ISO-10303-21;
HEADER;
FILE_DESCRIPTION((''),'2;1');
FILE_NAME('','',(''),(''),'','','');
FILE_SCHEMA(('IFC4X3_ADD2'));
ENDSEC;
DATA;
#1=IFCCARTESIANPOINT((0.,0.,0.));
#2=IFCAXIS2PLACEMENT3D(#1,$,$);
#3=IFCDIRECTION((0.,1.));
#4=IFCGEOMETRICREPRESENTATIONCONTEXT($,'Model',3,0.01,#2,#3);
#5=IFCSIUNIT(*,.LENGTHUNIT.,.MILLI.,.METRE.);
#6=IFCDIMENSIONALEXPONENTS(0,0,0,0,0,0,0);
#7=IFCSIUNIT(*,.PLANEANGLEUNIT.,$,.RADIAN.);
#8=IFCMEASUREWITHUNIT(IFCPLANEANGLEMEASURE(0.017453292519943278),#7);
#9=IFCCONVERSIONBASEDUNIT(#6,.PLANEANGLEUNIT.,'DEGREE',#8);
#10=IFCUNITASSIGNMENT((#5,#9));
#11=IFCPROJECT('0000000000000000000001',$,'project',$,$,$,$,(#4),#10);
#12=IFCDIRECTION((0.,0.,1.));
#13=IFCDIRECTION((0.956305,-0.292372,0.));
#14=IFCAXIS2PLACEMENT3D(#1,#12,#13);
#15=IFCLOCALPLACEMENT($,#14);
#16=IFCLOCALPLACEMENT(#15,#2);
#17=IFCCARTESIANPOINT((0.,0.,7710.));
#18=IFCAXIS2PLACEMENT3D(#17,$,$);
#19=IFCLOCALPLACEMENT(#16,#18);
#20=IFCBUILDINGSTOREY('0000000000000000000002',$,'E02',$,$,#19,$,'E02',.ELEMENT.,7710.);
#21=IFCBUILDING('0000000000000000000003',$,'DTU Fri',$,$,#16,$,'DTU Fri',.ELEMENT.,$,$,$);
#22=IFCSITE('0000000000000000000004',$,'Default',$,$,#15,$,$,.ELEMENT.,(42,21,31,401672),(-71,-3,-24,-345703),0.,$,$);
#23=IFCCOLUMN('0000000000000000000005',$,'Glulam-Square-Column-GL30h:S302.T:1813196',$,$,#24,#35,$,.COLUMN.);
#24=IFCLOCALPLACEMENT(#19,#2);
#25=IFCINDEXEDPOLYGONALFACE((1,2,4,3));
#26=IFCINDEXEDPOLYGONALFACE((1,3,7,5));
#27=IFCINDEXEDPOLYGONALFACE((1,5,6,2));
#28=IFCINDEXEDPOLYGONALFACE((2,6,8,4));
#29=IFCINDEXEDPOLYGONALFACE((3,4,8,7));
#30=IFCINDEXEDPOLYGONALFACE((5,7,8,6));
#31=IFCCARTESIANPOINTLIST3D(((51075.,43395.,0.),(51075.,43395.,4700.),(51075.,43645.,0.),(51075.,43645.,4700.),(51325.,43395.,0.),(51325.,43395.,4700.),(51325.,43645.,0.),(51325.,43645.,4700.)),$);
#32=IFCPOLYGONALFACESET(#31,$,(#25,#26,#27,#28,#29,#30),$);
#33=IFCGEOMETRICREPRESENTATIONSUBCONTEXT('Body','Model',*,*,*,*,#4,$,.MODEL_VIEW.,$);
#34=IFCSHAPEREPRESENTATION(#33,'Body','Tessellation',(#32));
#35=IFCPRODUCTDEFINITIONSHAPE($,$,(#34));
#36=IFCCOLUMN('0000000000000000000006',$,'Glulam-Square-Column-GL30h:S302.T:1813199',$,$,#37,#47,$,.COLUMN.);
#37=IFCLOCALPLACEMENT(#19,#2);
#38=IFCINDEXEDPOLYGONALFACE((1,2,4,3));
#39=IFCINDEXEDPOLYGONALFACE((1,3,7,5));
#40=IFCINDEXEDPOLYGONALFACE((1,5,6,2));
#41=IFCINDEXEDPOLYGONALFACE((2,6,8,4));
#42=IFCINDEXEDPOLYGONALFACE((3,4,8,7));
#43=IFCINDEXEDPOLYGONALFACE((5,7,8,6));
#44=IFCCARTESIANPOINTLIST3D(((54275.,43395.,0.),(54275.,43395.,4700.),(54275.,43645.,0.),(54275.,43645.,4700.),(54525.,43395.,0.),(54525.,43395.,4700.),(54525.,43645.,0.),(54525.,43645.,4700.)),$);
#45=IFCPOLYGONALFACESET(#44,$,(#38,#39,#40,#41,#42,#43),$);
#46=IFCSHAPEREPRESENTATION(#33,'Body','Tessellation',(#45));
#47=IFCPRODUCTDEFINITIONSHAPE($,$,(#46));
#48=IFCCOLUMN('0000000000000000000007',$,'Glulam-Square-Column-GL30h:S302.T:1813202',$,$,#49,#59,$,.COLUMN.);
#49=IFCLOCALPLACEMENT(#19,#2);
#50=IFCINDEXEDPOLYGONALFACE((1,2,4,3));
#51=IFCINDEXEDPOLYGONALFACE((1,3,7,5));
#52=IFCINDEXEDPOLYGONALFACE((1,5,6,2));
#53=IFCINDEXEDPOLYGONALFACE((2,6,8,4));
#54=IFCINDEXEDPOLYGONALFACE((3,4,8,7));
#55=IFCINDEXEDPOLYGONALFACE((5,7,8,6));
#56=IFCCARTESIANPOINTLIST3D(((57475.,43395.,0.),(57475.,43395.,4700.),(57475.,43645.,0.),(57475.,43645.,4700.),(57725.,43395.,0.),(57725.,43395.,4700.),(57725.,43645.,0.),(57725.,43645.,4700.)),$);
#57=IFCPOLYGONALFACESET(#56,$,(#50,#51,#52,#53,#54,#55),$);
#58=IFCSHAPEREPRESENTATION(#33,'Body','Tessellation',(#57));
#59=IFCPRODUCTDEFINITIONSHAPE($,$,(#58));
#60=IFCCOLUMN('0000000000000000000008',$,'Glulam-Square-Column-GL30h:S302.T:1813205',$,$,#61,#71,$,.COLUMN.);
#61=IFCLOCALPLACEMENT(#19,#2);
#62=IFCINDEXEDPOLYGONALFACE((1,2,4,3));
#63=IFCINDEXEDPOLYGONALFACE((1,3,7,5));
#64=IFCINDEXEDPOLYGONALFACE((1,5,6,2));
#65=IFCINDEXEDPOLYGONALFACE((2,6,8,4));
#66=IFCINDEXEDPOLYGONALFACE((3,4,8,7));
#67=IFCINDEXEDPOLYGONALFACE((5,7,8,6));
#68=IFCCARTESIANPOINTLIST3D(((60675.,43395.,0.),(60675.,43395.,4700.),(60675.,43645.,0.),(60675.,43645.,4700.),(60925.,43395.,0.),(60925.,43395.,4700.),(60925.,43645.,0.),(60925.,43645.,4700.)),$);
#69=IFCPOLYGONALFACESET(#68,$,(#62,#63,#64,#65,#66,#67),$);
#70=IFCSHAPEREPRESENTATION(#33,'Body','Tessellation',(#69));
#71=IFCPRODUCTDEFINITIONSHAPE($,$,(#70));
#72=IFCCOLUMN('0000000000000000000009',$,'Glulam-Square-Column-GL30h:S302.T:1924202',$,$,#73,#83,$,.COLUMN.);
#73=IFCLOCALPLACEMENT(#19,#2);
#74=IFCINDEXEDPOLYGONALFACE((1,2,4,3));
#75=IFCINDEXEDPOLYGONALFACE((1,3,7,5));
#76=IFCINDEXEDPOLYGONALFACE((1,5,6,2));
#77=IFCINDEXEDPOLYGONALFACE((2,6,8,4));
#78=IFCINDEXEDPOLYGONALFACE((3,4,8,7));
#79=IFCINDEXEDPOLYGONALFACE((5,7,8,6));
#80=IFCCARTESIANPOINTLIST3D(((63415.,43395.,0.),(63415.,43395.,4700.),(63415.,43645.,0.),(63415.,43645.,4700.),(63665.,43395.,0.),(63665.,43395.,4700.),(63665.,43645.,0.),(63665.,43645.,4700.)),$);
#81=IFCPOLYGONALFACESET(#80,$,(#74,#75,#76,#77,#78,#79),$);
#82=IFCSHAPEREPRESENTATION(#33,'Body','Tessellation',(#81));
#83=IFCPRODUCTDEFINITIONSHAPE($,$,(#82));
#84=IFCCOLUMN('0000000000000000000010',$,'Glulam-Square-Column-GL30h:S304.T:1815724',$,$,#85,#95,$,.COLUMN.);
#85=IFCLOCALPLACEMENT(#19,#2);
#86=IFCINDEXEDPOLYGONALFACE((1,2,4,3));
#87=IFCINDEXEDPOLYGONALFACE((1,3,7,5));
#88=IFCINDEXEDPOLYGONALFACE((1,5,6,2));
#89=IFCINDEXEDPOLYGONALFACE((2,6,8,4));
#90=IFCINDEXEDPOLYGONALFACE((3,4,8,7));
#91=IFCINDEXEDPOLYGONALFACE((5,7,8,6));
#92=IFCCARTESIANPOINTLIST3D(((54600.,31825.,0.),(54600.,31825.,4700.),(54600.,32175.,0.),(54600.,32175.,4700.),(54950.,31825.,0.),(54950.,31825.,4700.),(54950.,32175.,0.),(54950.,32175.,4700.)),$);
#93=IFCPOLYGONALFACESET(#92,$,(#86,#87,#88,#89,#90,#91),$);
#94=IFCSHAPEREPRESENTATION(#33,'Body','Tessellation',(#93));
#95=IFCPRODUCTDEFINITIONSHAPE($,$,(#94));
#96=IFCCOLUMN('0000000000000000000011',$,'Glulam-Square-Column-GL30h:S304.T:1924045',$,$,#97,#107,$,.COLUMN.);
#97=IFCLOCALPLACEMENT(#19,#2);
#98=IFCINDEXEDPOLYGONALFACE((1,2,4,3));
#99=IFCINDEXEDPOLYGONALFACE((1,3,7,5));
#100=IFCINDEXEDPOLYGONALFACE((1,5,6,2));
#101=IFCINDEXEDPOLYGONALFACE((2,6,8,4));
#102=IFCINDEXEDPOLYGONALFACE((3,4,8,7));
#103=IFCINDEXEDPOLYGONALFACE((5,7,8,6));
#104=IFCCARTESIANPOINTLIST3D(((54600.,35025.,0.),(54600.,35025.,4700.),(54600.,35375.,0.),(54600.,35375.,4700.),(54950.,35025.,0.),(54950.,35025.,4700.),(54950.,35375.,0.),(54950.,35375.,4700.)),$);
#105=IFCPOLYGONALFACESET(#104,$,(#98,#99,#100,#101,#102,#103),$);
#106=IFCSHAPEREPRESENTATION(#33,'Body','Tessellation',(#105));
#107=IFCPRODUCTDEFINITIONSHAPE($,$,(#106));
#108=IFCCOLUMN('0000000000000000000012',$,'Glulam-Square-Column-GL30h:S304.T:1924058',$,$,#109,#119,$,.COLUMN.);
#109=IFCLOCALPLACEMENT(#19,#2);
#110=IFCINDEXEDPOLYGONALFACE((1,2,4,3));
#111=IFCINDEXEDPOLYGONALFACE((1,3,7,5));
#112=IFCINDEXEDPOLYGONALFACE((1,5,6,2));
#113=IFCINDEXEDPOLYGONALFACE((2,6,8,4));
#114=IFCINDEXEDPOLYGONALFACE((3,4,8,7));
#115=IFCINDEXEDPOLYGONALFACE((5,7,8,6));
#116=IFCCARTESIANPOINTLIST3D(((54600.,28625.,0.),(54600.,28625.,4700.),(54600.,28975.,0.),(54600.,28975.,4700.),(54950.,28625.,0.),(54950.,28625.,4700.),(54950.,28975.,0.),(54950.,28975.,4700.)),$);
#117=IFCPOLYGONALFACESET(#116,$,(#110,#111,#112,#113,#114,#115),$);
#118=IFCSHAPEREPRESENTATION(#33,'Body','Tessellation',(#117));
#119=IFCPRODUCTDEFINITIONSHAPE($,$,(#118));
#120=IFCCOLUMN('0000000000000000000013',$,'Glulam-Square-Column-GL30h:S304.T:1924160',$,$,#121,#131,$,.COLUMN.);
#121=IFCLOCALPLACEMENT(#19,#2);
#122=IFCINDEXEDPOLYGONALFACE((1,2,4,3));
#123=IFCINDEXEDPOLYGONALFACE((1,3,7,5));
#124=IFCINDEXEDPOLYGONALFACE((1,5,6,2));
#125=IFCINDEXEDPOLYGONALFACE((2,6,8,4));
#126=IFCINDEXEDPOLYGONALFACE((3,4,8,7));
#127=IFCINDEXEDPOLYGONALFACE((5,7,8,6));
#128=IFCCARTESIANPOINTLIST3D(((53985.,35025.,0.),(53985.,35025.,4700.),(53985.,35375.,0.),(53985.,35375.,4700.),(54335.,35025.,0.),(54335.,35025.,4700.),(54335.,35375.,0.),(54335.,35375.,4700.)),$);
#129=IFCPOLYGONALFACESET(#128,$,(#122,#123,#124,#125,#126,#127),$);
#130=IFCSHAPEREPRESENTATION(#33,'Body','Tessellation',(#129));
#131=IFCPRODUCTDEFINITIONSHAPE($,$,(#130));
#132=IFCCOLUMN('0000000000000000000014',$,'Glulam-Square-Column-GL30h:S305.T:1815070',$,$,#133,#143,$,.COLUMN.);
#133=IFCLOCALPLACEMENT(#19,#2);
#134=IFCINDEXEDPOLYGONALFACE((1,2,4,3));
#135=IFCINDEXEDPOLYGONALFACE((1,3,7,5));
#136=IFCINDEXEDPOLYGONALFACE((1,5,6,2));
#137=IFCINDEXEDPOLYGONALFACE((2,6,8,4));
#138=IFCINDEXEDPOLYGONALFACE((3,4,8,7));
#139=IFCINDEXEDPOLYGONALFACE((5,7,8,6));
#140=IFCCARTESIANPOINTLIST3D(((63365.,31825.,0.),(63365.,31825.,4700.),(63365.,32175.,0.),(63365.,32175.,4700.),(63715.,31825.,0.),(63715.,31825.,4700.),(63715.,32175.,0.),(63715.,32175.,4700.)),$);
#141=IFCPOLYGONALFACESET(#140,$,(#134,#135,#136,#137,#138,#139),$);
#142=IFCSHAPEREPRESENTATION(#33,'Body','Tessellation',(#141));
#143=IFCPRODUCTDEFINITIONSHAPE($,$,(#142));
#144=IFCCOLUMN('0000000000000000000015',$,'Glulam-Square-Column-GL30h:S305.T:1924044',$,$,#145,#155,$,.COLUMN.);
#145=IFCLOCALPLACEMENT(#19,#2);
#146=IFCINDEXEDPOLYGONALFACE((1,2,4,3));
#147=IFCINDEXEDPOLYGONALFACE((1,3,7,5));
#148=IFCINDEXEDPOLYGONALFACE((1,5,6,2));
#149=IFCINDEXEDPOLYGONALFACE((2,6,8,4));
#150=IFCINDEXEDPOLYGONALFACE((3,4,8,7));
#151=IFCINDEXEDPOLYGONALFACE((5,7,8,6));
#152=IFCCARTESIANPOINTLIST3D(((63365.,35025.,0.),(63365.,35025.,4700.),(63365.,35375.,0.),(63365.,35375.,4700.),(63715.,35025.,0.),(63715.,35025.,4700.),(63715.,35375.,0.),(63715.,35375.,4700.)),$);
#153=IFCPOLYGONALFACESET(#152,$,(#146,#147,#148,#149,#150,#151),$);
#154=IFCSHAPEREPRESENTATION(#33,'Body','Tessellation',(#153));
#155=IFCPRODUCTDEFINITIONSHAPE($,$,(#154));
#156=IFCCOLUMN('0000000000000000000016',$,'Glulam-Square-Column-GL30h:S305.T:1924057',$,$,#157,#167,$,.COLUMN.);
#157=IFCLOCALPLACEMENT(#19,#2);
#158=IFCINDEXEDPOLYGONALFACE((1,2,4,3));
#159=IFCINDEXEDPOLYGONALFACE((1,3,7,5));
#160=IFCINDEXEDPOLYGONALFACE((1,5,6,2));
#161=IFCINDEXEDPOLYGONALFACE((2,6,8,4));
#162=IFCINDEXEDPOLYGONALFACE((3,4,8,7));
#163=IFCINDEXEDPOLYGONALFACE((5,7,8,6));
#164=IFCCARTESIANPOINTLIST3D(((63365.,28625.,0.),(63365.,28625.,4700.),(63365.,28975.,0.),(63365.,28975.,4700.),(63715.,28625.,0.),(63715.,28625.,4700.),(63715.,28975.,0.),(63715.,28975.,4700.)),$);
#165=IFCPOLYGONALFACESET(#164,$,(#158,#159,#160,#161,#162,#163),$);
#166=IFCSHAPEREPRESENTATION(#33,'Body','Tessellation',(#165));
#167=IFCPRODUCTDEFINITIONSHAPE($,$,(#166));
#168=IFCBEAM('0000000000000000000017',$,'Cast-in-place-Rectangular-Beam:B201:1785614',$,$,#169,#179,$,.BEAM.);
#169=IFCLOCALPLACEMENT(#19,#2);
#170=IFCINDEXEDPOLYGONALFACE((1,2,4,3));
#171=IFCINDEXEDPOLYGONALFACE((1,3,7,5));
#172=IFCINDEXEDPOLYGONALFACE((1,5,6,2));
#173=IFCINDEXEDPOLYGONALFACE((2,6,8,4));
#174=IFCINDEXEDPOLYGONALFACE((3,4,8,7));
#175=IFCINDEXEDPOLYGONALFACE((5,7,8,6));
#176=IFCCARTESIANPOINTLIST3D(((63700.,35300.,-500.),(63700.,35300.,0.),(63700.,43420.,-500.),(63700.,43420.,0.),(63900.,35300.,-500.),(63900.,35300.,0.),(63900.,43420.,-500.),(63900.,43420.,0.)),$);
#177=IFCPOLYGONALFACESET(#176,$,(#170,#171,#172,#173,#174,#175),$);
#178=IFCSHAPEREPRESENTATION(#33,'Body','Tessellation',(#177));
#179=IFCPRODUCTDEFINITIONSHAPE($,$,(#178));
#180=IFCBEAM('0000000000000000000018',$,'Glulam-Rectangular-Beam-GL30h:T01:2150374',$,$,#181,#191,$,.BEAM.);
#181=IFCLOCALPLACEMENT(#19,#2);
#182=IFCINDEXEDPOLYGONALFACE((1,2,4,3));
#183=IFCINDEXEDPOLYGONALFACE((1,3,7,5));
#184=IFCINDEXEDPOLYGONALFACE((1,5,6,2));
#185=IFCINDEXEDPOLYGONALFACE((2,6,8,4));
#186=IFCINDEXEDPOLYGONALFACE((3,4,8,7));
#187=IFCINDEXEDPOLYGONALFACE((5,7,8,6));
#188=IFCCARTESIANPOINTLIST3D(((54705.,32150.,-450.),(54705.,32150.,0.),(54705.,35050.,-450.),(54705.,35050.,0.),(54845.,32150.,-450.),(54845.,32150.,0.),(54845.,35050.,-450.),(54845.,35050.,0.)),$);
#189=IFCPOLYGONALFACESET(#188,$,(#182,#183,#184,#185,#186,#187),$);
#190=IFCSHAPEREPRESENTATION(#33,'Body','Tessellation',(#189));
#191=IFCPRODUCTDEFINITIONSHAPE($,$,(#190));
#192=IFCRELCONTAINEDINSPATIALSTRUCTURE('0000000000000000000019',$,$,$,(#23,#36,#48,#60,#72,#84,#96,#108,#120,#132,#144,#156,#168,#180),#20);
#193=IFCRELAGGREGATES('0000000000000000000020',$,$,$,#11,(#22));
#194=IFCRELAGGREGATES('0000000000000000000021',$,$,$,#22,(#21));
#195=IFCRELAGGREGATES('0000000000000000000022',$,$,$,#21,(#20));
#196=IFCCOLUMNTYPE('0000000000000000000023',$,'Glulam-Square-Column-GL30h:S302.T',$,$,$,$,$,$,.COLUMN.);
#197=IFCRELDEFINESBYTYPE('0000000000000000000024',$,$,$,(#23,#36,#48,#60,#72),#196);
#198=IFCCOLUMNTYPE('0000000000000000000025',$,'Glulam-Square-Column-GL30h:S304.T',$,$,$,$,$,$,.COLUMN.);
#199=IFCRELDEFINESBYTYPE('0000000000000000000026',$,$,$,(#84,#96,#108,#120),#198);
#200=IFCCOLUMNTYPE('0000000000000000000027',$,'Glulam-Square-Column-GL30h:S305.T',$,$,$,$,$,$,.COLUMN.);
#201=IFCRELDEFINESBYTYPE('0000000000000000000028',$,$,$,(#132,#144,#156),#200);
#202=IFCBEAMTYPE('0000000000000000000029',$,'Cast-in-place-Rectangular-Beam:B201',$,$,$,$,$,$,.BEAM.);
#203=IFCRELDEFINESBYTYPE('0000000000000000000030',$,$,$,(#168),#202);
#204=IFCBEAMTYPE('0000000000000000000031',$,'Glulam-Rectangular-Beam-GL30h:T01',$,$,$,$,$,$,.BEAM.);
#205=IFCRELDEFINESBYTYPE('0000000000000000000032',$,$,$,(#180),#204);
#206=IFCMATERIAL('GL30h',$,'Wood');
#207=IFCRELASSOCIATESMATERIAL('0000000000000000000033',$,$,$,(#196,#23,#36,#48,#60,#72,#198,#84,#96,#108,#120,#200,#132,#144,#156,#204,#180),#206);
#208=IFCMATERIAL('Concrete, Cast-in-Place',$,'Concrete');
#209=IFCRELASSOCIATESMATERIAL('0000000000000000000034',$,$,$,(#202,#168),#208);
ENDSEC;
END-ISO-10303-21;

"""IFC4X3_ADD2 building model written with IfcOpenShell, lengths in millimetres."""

from ifc_helpers import new_model, entity, si_unit, converted_unit, direction, frame, origin, origin_2d_with_axis, place, context, subcontext, project, spatial, rectangle, extrude, source, transform, mapped, material, material_profile, profile_set, profile_usage, type_object, type_shapes, element, save


model = new_model("IFC4X3_ADD2")

# Units and contexts
model_context = context("Model", 3, precision=0.01, world=origin(), true_north=direction((0.0, 1.0)))
body_context = subcontext(model_context, "Body", "Model", "MODEL_VIEW")
ifc_project = project(units=[si_unit("LENGTHUNIT", "METRE", prefix="MILLI"), converted_unit("PLANEANGLEUNIT", "DEGREE", entity("IfcPlaneAngleMeasure", 0.017453292519943278), si_unit("PLANEANGLEUNIT", "RADIAN"), dimensions=[0, 0, 0, 0, 0, 0, 0])], contexts=[model_context])

# Site, building, storey
site_placement = place(None, frame((0.0, 0.0, 0.0), z_axis=(0.0, 0.0, 1.0), x_axis=(0.956305, -0.292372, 0.0)))
site = spatial("IfcSite", under=ifc_project, at=site_placement, Name="Default", CompositionType="ELEMENT", RefLatitude=(42, 21, 31, 401672), RefLongitude=(-71, -3, -24, -345703), RefElevation=0.0)
building_placement = place(site_placement, origin())
building = spatial("IfcBuilding", under=site, at=building_placement, Name="DTU Fri", LongName="DTU Fri", CompositionType="ELEMENT")
storey_placement = place(building_placement, frame((0.0, 0.0, 7710.0)))
storey = spatial("IfcBuildingStorey", under=building, at=storey_placement, Name="E02", LongName="E02", CompositionType="ELEMENT", Elevation=7710.0)

# Columns
ifc_material_1 = material(Name="GL30h", Category="Wood")
ifc_material_profile_1 = material_profile(ifc_material_1, rectangle(XDim=250.0, YDim=250.0, at=origin_2d_with_axis()), Name="S302.T")
ifc_profile_set_1 = profile_set([ifc_material_profile_1], Name="S302.T")
ifc_profile_usage_1 = profile_usage(ifc_profile_set_1)
column_type_1 = type_object("IfcColumnType", Name="Glulam-Square-Column-GL30h:S302.T", PredefinedType="COLUMN", material=ifc_profile_set_1)
shared_shape_1 = source(origin(), body_context, "Body", "SweptSolid", [
    extrude(rectangle(XDim=250.0, YDim=250.0, at=origin_2d_with_axis()), frame((0.0, 0.0, 7710.0), z_axis=(0.0, 0.0, 1.0), x_axis=(0.0, 1.0, 0.0)), (0.0, 0.0, 1.0), 4700.0),
])
type_shapes(column_type_1, [shared_shape_1])
for number, where, name in (
    (1, (51200.0, 43520.0, -7710.0), "Glulam-Square-Column-GL30h:S302.T:1813196"),
    (2, (54400.0, 43520.0, -7710.0), "Glulam-Square-Column-GL30h:S302.T:1813199"),
    (3, (57600.0, 43520.0, -7710.0), "Glulam-Square-Column-GL30h:S302.T:1813202"),
    (4, (60800.0, 43520.0, -7710.0), "Glulam-Square-Column-GL30h:S302.T:1813205"),
    (5, (63540.0, 43520.0, -7710.0), "Glulam-Square-Column-GL30h:S302.T:1924202"),
):
    element("IfcColumn", number, at=place(storey_placement, frame(where)), inside=storey, type_object=column_type_1, material=ifc_profile_usage_1, Name=name, PredefinedType="COLUMN", context=body_context, shape_type="MappedRepresentation", body=[
        mapped(shared_shape_1, transform((0.0, 0.0, 0.0), scale=1.0)),
    ])
ifc_material_profile_2 = material_profile(ifc_material_1, rectangle(XDim=350.0, YDim=350.0, at=origin_2d_with_axis()), Name="S304.T")
ifc_profile_set_2 = profile_set([ifc_material_profile_2], Name="S304.T")
ifc_profile_usage_2 = profile_usage(ifc_profile_set_2)
column_type_2 = type_object("IfcColumnType", Name="Glulam-Square-Column-GL30h:S304.T", PredefinedType="COLUMN", material=ifc_profile_set_2)
shared_shape_2 = source(origin(), body_context, "Body", "SweptSolid", [
    extrude(rectangle(XDim=350.0, YDim=350.0, at=origin_2d_with_axis()), frame((0.0, 0.0, 7710.0), z_axis=(0.0, 0.0, 1.0), x_axis=(0.0, 1.0, 0.0)), (0.0, 0.0, 1.0), 4700.0),
])
type_shapes(column_type_2, [shared_shape_2])
for number, where, name in (
    (6, (54775.0, 32000.0, -7710.0), "Glulam-Square-Column-GL30h:S304.T:1815724"),
    (7, (54775.0, 35200.0, -7710.0), "Glulam-Square-Column-GL30h:S304.T:1924045"),
    (8, (54775.0, 28800.0, -7710.0), "Glulam-Square-Column-GL30h:S304.T:1924058"),
    (9, (54160.0, 35200.0, -7710.0), "Glulam-Square-Column-GL30h:S304.T:1924160"),
):
    element("IfcColumn", number, at=place(storey_placement, frame(where)), inside=storey, type_object=column_type_2, material=ifc_profile_usage_2, Name=name, PredefinedType="COLUMN", context=body_context, shape_type="MappedRepresentation", body=[
        mapped(shared_shape_2, transform((0.0, 0.0, 0.0), scale=1.0)),
    ])
ifc_material_profile_3 = material_profile(ifc_material_1, rectangle(XDim=350.0, YDim=350.0, at=origin_2d_with_axis()), Name="S305.T")
ifc_profile_set_3 = profile_set([ifc_material_profile_3], Name="S305.T")
ifc_profile_usage_3 = profile_usage(ifc_profile_set_3)
column_type_3 = type_object("IfcColumnType", Name="Glulam-Square-Column-GL30h:S305.T", PredefinedType="COLUMN", material=ifc_profile_set_3)
shared_shape_3 = source(origin(), body_context, "Body", "SweptSolid", [
    extrude(rectangle(XDim=350.0, YDim=350.0, at=origin_2d_with_axis()), frame((0.0, 0.0, 7710.0), z_axis=(0.0, 0.0, 1.0), x_axis=(0.0, 1.0, 0.0)), (0.0, 0.0, 1.0), 4700.0),
])
type_shapes(column_type_3, [shared_shape_3])
for number, where, name in (
    (10, (63540.0, 32000.0, -7710.0), "Glulam-Square-Column-GL30h:S305.T:1815070"),
    (11, (63540.0, 35200.0, -7710.0), "Glulam-Square-Column-GL30h:S305.T:1924044"),
    (12, (63540.0, 28800.0, -7710.0), "Glulam-Square-Column-GL30h:S305.T:1924057"),
):
    element("IfcColumn", number, at=place(storey_placement, frame(where)), inside=storey, type_object=column_type_3, material=ifc_profile_usage_3, Name=name, PredefinedType="COLUMN", context=body_context, shape_type="MappedRepresentation", body=[
        mapped(shared_shape_3, transform((0.0, 0.0, 0.0), scale=1.0)),
    ])

# Beams
ifc_material_2 = material(Name="Concrete, Cast-in-Place", Category="Concrete")
ifc_material_profile_4 = material_profile(ifc_material_2, rectangle(XDim=500.0, YDim=200.0, at=origin_2d_with_axis()), Name="B201")
ifc_profile_set_4 = profile_set([ifc_material_profile_4], Name="B201")
ifc_profile_usage_4 = profile_usage(ifc_profile_set_4, cardinal=8)
beam_type_1 = type_object("IfcBeamType", Name="Cast-in-place-Rectangular-Beam:B201", PredefinedType="BEAM", material=ifc_profile_set_4)
shared_shape_4 = source(origin(), body_context, "Body", "SweptSolid", [
    extrude(rectangle(XDim=500.0, YDim=200.0, at=origin_2d_with_axis()), frame((-4070.0, 0.0, 0.0), z_axis=(1.0, 0.0, 0.0), x_axis=(0.0, 0.0, -1.0)), (0.0, 0.0, 1.0), 8120.0),
])
type_shapes(beam_type_1, [shared_shape_4])
beam_1_placement = place(storey_placement, frame((63800.0, 39350.0, -250.0), z_axis=(0.0, 0.0, 1.0), x_axis=(0.0, -1.0, 0.0)))
element("IfcBeam", 13, at=beam_1_placement, inside=storey, type_object=beam_type_1, material=ifc_profile_usage_4, Name="Cast-in-place-Rectangular-Beam:B201:1785614", PredefinedType="BEAM", context=body_context, shape_type="MappedRepresentation", body=[
    mapped(shared_shape_4, transform((0.0, 0.0, 0.0), scale=1.0)),
])
ifc_material_profile_5 = material_profile(ifc_material_1, rectangle(XDim=450.0, YDim=140.0, at=origin_2d_with_axis()), Name="T01")
ifc_profile_set_5 = profile_set([ifc_material_profile_5], Name="T01")
ifc_profile_usage_5 = profile_usage(ifc_profile_set_5, cardinal=8)
beam_type_2 = type_object("IfcBeamType", Name="Glulam-Rectangular-Beam-GL30h:T01", PredefinedType="BEAM", material=ifc_profile_set_5)
shared_shape_5 = source(origin(), body_context, "Body", "SweptSolid", [
    extrude(rectangle(XDim=450.0, YDim=140.0, at=origin_2d_with_axis()), frame((-1450.0, 0.0, 0.0), z_axis=(1.0, 0.0, 0.0), x_axis=(0.0, 0.0, -1.0)), (0.0, 0.0, 1.0), 2900.0),
])
type_shapes(beam_type_2, [shared_shape_5])
beam_2_placement = place(storey_placement, frame((54775.0, 33600.0, -225.0), z_axis=(0.0, 0.0, 1.0), x_axis=(0.0, 1.0, 0.0)))
element("IfcBeam", 14, at=beam_2_placement, inside=storey, type_object=beam_type_2, material=ifc_profile_usage_5, Name="Glulam-Rectangular-Beam-GL30h:T01:2150374", PredefinedType="BEAM", context=body_context, shape_type="MappedRepresentation", body=[
    mapped(shared_shape_5, transform((0.0, 0.0, 0.0), scale=1.0)),
])

save(model, "model.ifc")
